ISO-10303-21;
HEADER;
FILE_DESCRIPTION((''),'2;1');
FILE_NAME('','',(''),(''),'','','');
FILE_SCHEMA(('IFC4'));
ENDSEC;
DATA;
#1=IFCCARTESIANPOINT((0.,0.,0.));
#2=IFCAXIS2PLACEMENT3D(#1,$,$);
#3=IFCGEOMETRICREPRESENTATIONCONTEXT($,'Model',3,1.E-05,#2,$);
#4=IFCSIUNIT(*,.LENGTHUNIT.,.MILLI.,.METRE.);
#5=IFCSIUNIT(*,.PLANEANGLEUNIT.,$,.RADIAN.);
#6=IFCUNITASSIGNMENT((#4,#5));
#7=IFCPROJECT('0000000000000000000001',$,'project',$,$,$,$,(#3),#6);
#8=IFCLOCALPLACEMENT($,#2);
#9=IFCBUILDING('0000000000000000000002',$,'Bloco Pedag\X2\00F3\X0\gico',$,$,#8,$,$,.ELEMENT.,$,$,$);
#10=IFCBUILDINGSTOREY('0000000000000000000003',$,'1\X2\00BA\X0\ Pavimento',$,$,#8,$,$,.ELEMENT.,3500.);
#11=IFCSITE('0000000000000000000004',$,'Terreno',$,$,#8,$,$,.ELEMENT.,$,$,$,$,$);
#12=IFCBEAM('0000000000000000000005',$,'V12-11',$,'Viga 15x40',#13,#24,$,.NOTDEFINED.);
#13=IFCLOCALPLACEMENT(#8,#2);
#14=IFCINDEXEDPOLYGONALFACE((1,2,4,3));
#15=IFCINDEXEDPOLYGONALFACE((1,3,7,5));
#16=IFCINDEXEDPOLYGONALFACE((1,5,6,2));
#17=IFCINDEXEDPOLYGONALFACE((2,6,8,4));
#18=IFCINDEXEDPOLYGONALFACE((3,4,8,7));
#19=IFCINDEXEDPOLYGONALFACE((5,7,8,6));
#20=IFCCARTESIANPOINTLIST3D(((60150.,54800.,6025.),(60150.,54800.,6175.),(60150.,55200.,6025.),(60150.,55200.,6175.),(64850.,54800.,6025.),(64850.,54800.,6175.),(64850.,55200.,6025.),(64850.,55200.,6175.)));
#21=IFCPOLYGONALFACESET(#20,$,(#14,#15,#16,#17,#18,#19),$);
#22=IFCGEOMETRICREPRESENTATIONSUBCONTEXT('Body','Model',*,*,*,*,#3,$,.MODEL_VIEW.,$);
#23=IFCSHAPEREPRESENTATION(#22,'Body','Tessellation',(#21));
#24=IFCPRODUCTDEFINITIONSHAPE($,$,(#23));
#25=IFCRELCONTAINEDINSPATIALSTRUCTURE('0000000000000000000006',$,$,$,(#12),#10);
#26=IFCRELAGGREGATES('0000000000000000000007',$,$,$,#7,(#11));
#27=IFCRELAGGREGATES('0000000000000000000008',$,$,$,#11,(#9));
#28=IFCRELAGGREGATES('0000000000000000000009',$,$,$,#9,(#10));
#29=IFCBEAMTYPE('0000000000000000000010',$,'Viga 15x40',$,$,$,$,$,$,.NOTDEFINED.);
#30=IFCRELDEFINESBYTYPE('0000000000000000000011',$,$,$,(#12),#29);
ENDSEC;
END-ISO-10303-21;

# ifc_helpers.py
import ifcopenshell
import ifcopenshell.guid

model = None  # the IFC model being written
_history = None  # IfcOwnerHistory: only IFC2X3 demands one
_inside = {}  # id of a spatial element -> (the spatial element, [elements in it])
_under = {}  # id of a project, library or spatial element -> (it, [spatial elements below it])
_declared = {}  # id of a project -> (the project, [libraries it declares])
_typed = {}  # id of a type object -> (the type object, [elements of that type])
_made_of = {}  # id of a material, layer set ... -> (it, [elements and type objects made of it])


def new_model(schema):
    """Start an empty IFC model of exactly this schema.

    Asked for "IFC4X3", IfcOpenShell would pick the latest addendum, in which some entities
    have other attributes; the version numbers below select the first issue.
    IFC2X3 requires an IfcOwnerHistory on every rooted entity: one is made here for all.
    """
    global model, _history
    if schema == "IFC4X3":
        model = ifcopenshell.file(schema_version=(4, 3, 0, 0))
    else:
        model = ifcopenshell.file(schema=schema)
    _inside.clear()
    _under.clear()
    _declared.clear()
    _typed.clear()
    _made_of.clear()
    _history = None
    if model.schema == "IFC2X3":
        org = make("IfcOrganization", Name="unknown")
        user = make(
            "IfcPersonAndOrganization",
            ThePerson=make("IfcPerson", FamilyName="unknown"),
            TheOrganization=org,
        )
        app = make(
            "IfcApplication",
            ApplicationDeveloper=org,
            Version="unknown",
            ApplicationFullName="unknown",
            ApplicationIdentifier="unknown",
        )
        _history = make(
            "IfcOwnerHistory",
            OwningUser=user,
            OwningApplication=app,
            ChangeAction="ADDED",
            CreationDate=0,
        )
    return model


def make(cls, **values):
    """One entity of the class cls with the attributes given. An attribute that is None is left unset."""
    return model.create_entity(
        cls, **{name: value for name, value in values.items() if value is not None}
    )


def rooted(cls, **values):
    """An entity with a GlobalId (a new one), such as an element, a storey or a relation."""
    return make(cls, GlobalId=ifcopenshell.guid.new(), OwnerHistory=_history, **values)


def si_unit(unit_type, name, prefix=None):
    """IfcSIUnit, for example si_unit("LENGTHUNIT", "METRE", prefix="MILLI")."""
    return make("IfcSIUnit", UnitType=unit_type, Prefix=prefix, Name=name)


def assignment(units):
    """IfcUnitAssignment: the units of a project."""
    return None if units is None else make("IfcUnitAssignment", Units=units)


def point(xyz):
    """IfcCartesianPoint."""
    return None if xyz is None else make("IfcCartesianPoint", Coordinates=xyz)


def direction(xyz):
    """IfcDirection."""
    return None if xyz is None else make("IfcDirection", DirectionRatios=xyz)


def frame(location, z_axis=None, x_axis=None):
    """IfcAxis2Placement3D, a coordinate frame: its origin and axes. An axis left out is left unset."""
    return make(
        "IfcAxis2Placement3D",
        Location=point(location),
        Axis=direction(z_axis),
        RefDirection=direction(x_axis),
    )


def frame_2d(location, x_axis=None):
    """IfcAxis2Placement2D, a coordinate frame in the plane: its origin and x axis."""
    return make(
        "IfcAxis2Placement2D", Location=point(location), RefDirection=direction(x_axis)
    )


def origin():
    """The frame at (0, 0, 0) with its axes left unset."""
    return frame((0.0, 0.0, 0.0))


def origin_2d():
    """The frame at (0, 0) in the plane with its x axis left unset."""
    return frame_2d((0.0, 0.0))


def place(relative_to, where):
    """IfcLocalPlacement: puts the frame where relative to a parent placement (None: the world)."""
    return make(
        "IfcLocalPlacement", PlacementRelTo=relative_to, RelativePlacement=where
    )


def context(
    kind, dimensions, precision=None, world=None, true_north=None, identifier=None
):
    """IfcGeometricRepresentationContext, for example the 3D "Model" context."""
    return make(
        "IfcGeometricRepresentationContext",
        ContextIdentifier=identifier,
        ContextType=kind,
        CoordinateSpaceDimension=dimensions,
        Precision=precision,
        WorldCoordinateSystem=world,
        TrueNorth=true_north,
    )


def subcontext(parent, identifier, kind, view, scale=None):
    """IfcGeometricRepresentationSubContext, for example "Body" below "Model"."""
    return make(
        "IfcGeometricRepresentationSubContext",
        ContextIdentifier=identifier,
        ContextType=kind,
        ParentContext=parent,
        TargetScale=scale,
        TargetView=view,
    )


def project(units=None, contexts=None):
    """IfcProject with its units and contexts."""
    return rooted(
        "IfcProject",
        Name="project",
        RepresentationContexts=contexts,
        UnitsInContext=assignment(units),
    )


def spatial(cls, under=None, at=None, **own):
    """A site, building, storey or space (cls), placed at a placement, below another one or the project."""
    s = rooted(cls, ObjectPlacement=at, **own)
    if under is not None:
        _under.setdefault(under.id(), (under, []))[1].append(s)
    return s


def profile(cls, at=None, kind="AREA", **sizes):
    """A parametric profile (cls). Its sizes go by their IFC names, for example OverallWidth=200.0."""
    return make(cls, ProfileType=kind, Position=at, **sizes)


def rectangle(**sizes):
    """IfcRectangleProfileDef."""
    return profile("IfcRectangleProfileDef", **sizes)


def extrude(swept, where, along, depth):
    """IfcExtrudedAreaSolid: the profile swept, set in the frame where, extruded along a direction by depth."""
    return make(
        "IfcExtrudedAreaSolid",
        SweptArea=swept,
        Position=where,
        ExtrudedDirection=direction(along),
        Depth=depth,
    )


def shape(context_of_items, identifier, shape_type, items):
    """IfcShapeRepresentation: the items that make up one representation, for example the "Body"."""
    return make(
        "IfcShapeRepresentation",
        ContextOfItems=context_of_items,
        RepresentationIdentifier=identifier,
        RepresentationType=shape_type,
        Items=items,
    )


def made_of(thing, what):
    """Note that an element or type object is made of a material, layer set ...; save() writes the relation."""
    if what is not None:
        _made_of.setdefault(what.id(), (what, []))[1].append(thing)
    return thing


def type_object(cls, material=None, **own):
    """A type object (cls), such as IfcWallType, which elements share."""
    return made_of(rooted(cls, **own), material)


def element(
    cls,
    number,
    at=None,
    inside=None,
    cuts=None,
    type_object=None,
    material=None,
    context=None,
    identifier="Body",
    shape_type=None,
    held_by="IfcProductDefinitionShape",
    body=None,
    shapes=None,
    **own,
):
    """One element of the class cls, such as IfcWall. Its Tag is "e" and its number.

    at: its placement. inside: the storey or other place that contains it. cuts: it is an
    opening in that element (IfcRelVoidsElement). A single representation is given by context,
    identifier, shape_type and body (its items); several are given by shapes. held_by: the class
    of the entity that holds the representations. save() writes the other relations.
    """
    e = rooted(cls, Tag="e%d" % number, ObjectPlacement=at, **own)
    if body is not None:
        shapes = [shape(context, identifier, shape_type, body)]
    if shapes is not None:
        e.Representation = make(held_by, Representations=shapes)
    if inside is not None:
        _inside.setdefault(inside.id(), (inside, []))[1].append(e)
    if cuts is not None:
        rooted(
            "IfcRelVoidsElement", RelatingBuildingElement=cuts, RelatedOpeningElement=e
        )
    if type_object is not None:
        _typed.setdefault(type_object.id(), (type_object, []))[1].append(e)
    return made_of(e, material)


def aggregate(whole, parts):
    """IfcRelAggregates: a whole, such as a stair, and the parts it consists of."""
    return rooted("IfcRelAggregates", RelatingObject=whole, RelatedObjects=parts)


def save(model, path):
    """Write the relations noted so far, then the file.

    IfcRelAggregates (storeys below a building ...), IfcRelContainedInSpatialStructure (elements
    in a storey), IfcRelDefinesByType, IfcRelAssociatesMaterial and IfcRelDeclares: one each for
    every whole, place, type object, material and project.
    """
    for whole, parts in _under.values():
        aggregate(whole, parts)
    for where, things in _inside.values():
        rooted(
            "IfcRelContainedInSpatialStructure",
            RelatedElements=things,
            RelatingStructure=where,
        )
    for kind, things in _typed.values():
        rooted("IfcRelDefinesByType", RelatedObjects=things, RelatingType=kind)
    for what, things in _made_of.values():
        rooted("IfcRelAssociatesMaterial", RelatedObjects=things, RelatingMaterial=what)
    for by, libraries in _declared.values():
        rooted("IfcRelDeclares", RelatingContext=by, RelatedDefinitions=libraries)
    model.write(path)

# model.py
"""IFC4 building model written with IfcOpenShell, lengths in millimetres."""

from ifc_helpers import new_model, si_unit, frame, origin, origin_2d, place, context, subcontext, project, spatial, rectangle, extrude, type_object, element, save


model = new_model("IFC4")

# Units and contexts
model_context = context("Model", 3, precision=1e-05, world=origin())
body_context = subcontext(model_context, "Body", "Model", "MODEL_VIEW")
ifc_project = project(units=[si_unit("LENGTHUNIT", "METRE", prefix="MILLI"), si_unit("PLANEANGLEUNIT", "RADIAN")], contexts=[model_context])

# Site, building, storey
placement = place(None, origin())
site = spatial("IfcSite", under=ifc_project, at=placement, Name="Terreno", CompositionType="ELEMENT")
building = spatial("IfcBuilding", under=site, at=placement, Name="Bloco Pedagógico", CompositionType="ELEMENT")
storey = spatial("IfcBuildingStorey", under=building, at=placement, Name="1º Pavimento", CompositionType="ELEMENT", Elevation=3500.0)

# Beam
beam_type = type_object("IfcBeamType", Name="Viga 15x40", PredefinedType="NOTDEFINED")
for number, where, z_axis, x_axis, name in (
    (1, (60150.0, 55000.0, 6100.0), (1.0, 0.0, 0.0), (0.0, 1.0, 0.0), "V12-11"),
):
    element("IfcBeam", number, at=place(None, frame(where, z_axis=z_axis, x_axis=x_axis)), inside=storey, type_object=beam_type, Name=name, ObjectType="Viga 15x40", PredefinedType="NOTDEFINED", context=body_context, shape_type="SweptSolid", body=[
        extrude(rectangle(XDim=400.0, YDim=150.0, at=origin_2d()), None, (0.0, 0.0, 1.0), 4700.0),
    ])

save(model, "model.ifc")
